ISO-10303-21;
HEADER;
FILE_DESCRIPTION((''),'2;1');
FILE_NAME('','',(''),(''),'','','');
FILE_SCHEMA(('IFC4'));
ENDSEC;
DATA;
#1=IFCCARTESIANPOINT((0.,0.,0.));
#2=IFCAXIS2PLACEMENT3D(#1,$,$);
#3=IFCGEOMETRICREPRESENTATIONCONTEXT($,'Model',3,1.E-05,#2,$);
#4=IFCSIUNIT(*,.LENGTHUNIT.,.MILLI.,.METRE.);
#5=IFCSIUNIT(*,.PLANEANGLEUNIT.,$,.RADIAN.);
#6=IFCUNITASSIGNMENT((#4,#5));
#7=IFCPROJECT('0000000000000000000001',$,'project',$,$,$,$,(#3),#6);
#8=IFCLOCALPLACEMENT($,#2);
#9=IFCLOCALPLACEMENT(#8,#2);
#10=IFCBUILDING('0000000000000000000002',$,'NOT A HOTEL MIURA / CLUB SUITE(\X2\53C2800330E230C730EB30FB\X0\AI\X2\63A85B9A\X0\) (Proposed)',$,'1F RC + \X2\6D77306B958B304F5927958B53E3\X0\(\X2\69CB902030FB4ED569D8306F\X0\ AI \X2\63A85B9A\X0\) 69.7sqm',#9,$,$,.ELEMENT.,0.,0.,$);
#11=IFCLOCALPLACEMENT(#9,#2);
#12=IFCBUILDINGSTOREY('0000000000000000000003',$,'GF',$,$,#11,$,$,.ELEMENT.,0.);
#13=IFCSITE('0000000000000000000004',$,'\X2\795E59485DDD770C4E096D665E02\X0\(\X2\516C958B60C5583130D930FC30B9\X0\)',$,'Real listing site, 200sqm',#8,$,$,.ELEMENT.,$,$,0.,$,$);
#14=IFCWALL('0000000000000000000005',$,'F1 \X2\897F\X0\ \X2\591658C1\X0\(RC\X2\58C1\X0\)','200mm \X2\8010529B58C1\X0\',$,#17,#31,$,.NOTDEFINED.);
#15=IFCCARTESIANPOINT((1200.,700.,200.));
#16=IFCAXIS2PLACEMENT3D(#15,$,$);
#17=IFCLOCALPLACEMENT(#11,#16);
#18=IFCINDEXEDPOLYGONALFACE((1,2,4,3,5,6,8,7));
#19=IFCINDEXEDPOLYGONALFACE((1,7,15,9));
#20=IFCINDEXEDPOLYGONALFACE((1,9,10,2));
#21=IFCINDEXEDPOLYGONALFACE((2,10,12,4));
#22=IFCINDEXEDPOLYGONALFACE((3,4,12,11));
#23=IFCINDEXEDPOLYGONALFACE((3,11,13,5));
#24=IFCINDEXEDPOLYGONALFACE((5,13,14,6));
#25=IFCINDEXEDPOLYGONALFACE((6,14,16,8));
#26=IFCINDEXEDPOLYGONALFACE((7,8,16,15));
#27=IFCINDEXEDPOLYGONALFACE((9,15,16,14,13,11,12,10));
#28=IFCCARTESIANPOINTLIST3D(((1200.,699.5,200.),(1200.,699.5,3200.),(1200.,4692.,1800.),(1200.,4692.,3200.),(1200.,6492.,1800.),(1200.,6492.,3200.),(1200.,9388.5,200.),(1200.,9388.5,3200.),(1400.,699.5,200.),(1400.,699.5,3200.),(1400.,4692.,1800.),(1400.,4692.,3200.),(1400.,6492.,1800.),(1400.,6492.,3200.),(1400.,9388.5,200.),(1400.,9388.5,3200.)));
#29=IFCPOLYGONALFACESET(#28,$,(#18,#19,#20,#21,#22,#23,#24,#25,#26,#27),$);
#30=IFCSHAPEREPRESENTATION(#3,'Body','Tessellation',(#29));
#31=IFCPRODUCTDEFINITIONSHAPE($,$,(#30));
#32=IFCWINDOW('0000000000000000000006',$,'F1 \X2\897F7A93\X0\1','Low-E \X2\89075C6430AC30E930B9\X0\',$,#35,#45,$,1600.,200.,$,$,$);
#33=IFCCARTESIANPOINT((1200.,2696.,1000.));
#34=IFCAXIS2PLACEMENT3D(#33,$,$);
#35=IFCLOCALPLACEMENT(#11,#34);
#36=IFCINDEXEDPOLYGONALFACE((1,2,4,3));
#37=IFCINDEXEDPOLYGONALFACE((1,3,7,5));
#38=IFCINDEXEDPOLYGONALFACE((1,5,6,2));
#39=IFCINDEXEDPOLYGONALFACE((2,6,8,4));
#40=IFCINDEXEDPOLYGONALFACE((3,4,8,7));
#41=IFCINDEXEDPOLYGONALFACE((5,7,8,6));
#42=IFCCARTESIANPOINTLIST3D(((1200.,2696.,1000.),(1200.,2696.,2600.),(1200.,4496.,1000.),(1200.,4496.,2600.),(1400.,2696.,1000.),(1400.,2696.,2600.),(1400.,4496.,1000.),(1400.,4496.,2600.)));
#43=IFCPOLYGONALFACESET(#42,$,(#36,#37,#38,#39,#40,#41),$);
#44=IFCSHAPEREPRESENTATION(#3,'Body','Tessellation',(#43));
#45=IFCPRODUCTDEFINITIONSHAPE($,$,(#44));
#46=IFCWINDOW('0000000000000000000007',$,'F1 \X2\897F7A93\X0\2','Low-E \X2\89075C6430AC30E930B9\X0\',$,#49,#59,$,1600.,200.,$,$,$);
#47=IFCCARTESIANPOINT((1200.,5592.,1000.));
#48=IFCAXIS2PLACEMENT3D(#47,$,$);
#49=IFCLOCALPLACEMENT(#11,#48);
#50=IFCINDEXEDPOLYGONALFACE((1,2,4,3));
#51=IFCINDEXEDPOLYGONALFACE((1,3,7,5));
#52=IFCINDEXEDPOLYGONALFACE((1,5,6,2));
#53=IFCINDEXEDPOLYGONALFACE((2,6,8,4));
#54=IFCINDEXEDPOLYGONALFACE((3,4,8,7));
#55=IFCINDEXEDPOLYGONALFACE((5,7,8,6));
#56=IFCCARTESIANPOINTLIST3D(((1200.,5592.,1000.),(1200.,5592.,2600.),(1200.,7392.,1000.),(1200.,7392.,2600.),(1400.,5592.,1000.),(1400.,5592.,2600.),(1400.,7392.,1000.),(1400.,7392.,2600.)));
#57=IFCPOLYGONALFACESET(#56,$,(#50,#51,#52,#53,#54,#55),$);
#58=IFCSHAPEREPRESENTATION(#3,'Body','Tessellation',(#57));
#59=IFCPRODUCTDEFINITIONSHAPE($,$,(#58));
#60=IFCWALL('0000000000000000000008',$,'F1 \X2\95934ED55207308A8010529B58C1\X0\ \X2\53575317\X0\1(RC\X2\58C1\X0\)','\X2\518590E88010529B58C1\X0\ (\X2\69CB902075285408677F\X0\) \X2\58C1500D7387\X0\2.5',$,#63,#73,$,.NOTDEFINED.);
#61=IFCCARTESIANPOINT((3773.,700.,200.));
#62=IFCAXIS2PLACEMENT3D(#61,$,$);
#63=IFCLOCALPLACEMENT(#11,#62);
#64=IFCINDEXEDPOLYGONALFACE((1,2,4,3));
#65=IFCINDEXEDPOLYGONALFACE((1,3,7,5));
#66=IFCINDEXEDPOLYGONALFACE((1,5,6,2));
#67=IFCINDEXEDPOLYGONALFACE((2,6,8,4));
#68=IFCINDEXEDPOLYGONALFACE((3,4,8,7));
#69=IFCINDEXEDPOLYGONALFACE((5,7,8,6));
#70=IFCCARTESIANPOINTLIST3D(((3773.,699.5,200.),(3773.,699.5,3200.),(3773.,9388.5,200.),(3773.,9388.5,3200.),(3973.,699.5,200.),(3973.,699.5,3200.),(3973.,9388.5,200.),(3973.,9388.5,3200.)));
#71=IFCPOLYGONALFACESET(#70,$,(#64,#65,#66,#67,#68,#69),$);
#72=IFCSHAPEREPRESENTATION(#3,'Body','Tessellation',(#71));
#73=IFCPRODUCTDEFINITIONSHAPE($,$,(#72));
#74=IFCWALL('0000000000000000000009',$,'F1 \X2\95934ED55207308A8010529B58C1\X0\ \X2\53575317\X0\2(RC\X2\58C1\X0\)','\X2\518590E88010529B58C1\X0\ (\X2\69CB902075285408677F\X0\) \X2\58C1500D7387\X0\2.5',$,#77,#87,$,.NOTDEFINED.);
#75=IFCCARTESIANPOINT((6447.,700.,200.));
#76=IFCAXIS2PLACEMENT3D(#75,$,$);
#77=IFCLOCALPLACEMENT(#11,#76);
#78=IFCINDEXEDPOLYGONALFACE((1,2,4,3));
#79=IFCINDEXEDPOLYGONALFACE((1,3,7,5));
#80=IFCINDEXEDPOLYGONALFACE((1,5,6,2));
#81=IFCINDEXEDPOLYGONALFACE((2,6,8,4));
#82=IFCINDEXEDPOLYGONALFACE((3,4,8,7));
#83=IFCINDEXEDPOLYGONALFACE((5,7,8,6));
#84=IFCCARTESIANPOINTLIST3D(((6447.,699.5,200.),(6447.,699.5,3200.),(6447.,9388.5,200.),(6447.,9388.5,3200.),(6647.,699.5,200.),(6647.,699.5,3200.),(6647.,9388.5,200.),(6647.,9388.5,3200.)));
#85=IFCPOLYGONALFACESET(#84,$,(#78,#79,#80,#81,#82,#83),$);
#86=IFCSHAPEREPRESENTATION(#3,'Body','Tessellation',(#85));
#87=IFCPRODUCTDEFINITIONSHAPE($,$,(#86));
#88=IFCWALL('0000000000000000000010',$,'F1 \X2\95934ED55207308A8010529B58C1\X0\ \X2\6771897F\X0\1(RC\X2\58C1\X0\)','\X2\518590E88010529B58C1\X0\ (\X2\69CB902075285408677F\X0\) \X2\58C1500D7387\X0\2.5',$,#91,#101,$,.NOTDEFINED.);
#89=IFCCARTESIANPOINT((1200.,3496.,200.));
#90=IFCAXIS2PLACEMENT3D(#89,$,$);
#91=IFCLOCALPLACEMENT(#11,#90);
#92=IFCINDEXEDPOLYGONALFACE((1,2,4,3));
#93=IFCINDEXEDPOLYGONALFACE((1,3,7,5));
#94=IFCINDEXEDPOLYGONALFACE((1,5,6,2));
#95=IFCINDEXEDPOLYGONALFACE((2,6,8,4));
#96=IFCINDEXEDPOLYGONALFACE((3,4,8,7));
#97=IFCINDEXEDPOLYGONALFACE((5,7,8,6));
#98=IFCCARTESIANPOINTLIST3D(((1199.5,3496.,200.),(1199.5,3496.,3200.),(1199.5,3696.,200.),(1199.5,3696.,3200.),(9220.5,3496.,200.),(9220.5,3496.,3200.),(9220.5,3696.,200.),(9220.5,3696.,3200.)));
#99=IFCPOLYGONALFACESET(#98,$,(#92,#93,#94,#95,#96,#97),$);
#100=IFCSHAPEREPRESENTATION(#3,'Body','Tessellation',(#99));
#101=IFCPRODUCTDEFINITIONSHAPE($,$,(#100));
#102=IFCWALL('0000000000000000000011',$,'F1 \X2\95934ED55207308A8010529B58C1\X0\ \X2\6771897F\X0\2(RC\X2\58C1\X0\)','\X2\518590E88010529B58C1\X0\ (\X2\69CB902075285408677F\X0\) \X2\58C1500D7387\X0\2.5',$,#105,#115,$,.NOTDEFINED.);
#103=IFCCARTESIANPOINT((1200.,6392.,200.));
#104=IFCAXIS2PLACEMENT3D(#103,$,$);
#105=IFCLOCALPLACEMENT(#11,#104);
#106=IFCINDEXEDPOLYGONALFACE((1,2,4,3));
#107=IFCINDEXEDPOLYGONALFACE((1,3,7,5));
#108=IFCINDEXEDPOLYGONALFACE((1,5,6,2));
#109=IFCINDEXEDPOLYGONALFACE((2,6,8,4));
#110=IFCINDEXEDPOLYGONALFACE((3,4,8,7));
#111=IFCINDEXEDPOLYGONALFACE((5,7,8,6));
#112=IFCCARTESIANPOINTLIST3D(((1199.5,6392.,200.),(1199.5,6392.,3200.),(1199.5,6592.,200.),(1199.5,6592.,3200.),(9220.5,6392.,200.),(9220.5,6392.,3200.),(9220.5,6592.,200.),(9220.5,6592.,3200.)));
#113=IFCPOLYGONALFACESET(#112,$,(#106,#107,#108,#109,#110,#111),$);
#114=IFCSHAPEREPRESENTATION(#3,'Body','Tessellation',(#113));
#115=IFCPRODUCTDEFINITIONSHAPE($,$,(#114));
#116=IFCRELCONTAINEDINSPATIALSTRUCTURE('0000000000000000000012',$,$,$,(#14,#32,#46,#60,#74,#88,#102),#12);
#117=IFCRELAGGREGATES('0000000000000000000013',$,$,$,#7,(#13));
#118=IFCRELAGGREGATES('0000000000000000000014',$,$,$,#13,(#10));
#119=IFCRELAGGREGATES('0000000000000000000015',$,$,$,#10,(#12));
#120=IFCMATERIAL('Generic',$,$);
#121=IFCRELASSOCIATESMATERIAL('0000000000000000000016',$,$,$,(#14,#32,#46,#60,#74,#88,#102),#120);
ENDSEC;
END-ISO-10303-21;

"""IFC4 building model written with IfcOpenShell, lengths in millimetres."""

from ifc_helpers import new_model, si_unit, frame, frame_2d, origin, place, context, project, spatial, rectangle, extrude, material, element, fill, save


model = new_model("IFC4")

# Units and contexts
model_context = context("Model", 3, precision=1e-05, world=origin())
ifc_project = project(units=[si_unit("LENGTHUNIT", "METRE", prefix="MILLI"), si_unit("PLANEANGLEUNIT", "RADIAN")], contexts=[model_context])

# Site, building, storey
site_placement = place(None, origin())
site = spatial("IfcSite", under=ifc_project, at=site_placement, Name="神奈川県三浦市(公開情報ベース)", ObjectType="Real listing site, 200sqm", CompositionType="ELEMENT", RefElevation=0.0)
building_placement = place(site_placement, origin())
building = spatial("IfcBuilding", under=site, at=building_placement, Name="NOT A HOTEL MIURA / CLUB SUITE(参考モデル・AI推定) (Proposed)", ObjectType="1F RC + 海に開く大開口(構造・仕様は AI 推定) 69.7sqm", CompositionType="ELEMENT", ElevationOfRefHeight=0.0, ElevationOfTerrain=0.0)
storey_placement = place(building_placement, origin())
storey = spatial("IfcBuildingStorey", under=building, at=storey_placement, Name="GF", CompositionType="ELEMENT", Elevation=0.0)

# Shared definitions
ifc_material_1 = material(Name="Generic")

# Wall, openings, windows
wall_1_placement = place(storey_placement, frame((1200.0, 700.0, 200.0)))
wall_1 = element("IfcWall", 1, at=wall_1_placement, inside=storey, material=ifc_material_1, Name="F1 西 外壁(RC壁)", Description="200mm 耐力壁", PredefinedType="NOTDEFINED", context=model_context, shape_type="SweptSolid", body=[
    extrude(rectangle(XDim=200.0, YDim=8689.0, at=frame_2d((100.0, 4344.0))), frame((1200.0, 700.0, 200.0)), (0.0, 0.0, 1.0), 3000.0),
])
opening_1_placement = place(storey_placement, frame((1200.0, 2696.0, 1000.0)))
opening_1 = element("IfcOpeningElement", 2, at=opening_1_placement, cuts=wall_1, PredefinedType="NOTDEFINED", context=model_context, shape_type="SweptSolid", body=[
    extrude(rectangle(XDim=200.0, YDim=1800.0, at=frame_2d((100.0, 900.0))), frame((1200.0, 2696.0, 1000.0)), (0.0, 0.0, 1.0), 1600.0),
])
opening_2_placement = place(storey_placement, frame((1200.0, 5592.0, 1000.0)))
opening_2 = element("IfcOpeningElement", 3, at=opening_2_placement, cuts=wall_1, PredefinedType="NOTDEFINED", context=model_context, shape_type="SweptSolid", body=[
    extrude(rectangle(XDim=200.0, YDim=1800.0, at=frame_2d((100.0, 900.0))), frame((1200.0, 5592.0, 1000.0)), (0.0, 0.0, 1.0), 1600.0),
])
window_1_placement = place(storey_placement, frame((1200.0, 2696.0, 1000.0)))
window_1 = element("IfcWindow", 4, at=window_1_placement, inside=storey, material=ifc_material_1, Name="F1 西窓1", Description="Low-E 複層ガラス", OverallHeight=1600.0, OverallWidth=200.0, context=model_context, shape_type="SweptSolid", body=[
    extrude(rectangle(XDim=200.0, YDim=1800.0, at=frame_2d((100.0, 900.0))), frame((1200.0, 2696.0, 1000.0)), (0.0, 0.0, 1.0), 1600.0),
])
fill(opening_1, window_1)
window_2_placement = place(storey_placement, frame((1200.0, 5592.0, 1000.0)))
window_2 = element("IfcWindow", 5, at=window_2_placement, inside=storey, material=ifc_material_1, Name="F1 西窓2", Description="Low-E 複層ガラス", OverallHeight=1600.0, OverallWidth=200.0, context=model_context, shape_type="SweptSolid", body=[
    extrude(rectangle(XDim=200.0, YDim=1800.0, at=frame_2d((100.0, 900.0))), frame((1200.0, 5592.0, 1000.0)), (0.0, 0.0, 1.0), 1600.0),
])
fill(opening_2, window_2)

# Walls
wall_2_placement = place(storey_placement, frame((3773.0, 700.0, 200.0)))
element("IfcWall", 6, at=wall_2_placement, inside=storey, material=ifc_material_1, Name="F1 間仕切り耐力壁 南北1(RC壁)", Description="内部耐力壁 (構造用合板) 壁倍率2.5", PredefinedType="NOTDEFINED", context=model_context, shape_type="SweptSolid", body=[
    extrude(rectangle(XDim=200.0, YDim=8689.0, at=frame_2d((100.0, 4344.0))), frame((3773.0, 700.0, 200.0)), (0.0, 0.0, 1.0), 3000.0),
])
wall_3_placement = place(storey_placement, frame((6447.0, 700.0, 200.0)))
element("IfcWall", 7, at=wall_3_placement, inside=storey, material=ifc_material_1, Name="F1 間仕切り耐力壁 南北2(RC壁)", Description="内部耐力壁 (構造用合板) 壁倍率2.5", PredefinedType="NOTDEFINED", context=model_context, shape_type="SweptSolid", body=[
    extrude(rectangle(XDim=200.0, YDim=8689.0, at=frame_2d((100.0, 4344.0))), frame((6447.0, 700.0, 200.0)), (0.0, 0.0, 1.0), 3000.0),
])
wall_4_placement = place(storey_placement, frame((1200.0, 3496.0, 200.0)))
element("IfcWall", 8, at=wall_4_placement, inside=storey, material=ifc_material_1, Name="F1 間仕切り耐力壁 東西1(RC壁)", Description="内部耐力壁 (構造用合板) 壁倍率2.5", PredefinedType="NOTDEFINED", context=model_context, shape_type="SweptSolid", body=[
    extrude(rectangle(XDim=8021.0, YDim=200.0, at=frame_2d((4010.0, 100.0))), frame((1200.0, 3496.0, 200.0)), (0.0, 0.0, 1.0), 3000.0),
])
wall_5_placement = place(storey_placement, frame((1200.0, 6392.0, 200.0)))
element("IfcWall", 9, at=wall_5_placement, inside=storey, material=ifc_material_1, Name="F1 間仕切り耐力壁 東西2(RC壁)", Description="内部耐力壁 (構造用合板) 壁倍率2.5", PredefinedType="NOTDEFINED", context=model_context, shape_type="SweptSolid", body=[
    extrude(rectangle(XDim=8021.0, YDim=200.0, at=frame_2d((4010.0, 100.0))), frame((1200.0, 6392.0, 200.0)), (0.0, 0.0, 1.0), 3000.0),
])

save(model, "model.ifc")
